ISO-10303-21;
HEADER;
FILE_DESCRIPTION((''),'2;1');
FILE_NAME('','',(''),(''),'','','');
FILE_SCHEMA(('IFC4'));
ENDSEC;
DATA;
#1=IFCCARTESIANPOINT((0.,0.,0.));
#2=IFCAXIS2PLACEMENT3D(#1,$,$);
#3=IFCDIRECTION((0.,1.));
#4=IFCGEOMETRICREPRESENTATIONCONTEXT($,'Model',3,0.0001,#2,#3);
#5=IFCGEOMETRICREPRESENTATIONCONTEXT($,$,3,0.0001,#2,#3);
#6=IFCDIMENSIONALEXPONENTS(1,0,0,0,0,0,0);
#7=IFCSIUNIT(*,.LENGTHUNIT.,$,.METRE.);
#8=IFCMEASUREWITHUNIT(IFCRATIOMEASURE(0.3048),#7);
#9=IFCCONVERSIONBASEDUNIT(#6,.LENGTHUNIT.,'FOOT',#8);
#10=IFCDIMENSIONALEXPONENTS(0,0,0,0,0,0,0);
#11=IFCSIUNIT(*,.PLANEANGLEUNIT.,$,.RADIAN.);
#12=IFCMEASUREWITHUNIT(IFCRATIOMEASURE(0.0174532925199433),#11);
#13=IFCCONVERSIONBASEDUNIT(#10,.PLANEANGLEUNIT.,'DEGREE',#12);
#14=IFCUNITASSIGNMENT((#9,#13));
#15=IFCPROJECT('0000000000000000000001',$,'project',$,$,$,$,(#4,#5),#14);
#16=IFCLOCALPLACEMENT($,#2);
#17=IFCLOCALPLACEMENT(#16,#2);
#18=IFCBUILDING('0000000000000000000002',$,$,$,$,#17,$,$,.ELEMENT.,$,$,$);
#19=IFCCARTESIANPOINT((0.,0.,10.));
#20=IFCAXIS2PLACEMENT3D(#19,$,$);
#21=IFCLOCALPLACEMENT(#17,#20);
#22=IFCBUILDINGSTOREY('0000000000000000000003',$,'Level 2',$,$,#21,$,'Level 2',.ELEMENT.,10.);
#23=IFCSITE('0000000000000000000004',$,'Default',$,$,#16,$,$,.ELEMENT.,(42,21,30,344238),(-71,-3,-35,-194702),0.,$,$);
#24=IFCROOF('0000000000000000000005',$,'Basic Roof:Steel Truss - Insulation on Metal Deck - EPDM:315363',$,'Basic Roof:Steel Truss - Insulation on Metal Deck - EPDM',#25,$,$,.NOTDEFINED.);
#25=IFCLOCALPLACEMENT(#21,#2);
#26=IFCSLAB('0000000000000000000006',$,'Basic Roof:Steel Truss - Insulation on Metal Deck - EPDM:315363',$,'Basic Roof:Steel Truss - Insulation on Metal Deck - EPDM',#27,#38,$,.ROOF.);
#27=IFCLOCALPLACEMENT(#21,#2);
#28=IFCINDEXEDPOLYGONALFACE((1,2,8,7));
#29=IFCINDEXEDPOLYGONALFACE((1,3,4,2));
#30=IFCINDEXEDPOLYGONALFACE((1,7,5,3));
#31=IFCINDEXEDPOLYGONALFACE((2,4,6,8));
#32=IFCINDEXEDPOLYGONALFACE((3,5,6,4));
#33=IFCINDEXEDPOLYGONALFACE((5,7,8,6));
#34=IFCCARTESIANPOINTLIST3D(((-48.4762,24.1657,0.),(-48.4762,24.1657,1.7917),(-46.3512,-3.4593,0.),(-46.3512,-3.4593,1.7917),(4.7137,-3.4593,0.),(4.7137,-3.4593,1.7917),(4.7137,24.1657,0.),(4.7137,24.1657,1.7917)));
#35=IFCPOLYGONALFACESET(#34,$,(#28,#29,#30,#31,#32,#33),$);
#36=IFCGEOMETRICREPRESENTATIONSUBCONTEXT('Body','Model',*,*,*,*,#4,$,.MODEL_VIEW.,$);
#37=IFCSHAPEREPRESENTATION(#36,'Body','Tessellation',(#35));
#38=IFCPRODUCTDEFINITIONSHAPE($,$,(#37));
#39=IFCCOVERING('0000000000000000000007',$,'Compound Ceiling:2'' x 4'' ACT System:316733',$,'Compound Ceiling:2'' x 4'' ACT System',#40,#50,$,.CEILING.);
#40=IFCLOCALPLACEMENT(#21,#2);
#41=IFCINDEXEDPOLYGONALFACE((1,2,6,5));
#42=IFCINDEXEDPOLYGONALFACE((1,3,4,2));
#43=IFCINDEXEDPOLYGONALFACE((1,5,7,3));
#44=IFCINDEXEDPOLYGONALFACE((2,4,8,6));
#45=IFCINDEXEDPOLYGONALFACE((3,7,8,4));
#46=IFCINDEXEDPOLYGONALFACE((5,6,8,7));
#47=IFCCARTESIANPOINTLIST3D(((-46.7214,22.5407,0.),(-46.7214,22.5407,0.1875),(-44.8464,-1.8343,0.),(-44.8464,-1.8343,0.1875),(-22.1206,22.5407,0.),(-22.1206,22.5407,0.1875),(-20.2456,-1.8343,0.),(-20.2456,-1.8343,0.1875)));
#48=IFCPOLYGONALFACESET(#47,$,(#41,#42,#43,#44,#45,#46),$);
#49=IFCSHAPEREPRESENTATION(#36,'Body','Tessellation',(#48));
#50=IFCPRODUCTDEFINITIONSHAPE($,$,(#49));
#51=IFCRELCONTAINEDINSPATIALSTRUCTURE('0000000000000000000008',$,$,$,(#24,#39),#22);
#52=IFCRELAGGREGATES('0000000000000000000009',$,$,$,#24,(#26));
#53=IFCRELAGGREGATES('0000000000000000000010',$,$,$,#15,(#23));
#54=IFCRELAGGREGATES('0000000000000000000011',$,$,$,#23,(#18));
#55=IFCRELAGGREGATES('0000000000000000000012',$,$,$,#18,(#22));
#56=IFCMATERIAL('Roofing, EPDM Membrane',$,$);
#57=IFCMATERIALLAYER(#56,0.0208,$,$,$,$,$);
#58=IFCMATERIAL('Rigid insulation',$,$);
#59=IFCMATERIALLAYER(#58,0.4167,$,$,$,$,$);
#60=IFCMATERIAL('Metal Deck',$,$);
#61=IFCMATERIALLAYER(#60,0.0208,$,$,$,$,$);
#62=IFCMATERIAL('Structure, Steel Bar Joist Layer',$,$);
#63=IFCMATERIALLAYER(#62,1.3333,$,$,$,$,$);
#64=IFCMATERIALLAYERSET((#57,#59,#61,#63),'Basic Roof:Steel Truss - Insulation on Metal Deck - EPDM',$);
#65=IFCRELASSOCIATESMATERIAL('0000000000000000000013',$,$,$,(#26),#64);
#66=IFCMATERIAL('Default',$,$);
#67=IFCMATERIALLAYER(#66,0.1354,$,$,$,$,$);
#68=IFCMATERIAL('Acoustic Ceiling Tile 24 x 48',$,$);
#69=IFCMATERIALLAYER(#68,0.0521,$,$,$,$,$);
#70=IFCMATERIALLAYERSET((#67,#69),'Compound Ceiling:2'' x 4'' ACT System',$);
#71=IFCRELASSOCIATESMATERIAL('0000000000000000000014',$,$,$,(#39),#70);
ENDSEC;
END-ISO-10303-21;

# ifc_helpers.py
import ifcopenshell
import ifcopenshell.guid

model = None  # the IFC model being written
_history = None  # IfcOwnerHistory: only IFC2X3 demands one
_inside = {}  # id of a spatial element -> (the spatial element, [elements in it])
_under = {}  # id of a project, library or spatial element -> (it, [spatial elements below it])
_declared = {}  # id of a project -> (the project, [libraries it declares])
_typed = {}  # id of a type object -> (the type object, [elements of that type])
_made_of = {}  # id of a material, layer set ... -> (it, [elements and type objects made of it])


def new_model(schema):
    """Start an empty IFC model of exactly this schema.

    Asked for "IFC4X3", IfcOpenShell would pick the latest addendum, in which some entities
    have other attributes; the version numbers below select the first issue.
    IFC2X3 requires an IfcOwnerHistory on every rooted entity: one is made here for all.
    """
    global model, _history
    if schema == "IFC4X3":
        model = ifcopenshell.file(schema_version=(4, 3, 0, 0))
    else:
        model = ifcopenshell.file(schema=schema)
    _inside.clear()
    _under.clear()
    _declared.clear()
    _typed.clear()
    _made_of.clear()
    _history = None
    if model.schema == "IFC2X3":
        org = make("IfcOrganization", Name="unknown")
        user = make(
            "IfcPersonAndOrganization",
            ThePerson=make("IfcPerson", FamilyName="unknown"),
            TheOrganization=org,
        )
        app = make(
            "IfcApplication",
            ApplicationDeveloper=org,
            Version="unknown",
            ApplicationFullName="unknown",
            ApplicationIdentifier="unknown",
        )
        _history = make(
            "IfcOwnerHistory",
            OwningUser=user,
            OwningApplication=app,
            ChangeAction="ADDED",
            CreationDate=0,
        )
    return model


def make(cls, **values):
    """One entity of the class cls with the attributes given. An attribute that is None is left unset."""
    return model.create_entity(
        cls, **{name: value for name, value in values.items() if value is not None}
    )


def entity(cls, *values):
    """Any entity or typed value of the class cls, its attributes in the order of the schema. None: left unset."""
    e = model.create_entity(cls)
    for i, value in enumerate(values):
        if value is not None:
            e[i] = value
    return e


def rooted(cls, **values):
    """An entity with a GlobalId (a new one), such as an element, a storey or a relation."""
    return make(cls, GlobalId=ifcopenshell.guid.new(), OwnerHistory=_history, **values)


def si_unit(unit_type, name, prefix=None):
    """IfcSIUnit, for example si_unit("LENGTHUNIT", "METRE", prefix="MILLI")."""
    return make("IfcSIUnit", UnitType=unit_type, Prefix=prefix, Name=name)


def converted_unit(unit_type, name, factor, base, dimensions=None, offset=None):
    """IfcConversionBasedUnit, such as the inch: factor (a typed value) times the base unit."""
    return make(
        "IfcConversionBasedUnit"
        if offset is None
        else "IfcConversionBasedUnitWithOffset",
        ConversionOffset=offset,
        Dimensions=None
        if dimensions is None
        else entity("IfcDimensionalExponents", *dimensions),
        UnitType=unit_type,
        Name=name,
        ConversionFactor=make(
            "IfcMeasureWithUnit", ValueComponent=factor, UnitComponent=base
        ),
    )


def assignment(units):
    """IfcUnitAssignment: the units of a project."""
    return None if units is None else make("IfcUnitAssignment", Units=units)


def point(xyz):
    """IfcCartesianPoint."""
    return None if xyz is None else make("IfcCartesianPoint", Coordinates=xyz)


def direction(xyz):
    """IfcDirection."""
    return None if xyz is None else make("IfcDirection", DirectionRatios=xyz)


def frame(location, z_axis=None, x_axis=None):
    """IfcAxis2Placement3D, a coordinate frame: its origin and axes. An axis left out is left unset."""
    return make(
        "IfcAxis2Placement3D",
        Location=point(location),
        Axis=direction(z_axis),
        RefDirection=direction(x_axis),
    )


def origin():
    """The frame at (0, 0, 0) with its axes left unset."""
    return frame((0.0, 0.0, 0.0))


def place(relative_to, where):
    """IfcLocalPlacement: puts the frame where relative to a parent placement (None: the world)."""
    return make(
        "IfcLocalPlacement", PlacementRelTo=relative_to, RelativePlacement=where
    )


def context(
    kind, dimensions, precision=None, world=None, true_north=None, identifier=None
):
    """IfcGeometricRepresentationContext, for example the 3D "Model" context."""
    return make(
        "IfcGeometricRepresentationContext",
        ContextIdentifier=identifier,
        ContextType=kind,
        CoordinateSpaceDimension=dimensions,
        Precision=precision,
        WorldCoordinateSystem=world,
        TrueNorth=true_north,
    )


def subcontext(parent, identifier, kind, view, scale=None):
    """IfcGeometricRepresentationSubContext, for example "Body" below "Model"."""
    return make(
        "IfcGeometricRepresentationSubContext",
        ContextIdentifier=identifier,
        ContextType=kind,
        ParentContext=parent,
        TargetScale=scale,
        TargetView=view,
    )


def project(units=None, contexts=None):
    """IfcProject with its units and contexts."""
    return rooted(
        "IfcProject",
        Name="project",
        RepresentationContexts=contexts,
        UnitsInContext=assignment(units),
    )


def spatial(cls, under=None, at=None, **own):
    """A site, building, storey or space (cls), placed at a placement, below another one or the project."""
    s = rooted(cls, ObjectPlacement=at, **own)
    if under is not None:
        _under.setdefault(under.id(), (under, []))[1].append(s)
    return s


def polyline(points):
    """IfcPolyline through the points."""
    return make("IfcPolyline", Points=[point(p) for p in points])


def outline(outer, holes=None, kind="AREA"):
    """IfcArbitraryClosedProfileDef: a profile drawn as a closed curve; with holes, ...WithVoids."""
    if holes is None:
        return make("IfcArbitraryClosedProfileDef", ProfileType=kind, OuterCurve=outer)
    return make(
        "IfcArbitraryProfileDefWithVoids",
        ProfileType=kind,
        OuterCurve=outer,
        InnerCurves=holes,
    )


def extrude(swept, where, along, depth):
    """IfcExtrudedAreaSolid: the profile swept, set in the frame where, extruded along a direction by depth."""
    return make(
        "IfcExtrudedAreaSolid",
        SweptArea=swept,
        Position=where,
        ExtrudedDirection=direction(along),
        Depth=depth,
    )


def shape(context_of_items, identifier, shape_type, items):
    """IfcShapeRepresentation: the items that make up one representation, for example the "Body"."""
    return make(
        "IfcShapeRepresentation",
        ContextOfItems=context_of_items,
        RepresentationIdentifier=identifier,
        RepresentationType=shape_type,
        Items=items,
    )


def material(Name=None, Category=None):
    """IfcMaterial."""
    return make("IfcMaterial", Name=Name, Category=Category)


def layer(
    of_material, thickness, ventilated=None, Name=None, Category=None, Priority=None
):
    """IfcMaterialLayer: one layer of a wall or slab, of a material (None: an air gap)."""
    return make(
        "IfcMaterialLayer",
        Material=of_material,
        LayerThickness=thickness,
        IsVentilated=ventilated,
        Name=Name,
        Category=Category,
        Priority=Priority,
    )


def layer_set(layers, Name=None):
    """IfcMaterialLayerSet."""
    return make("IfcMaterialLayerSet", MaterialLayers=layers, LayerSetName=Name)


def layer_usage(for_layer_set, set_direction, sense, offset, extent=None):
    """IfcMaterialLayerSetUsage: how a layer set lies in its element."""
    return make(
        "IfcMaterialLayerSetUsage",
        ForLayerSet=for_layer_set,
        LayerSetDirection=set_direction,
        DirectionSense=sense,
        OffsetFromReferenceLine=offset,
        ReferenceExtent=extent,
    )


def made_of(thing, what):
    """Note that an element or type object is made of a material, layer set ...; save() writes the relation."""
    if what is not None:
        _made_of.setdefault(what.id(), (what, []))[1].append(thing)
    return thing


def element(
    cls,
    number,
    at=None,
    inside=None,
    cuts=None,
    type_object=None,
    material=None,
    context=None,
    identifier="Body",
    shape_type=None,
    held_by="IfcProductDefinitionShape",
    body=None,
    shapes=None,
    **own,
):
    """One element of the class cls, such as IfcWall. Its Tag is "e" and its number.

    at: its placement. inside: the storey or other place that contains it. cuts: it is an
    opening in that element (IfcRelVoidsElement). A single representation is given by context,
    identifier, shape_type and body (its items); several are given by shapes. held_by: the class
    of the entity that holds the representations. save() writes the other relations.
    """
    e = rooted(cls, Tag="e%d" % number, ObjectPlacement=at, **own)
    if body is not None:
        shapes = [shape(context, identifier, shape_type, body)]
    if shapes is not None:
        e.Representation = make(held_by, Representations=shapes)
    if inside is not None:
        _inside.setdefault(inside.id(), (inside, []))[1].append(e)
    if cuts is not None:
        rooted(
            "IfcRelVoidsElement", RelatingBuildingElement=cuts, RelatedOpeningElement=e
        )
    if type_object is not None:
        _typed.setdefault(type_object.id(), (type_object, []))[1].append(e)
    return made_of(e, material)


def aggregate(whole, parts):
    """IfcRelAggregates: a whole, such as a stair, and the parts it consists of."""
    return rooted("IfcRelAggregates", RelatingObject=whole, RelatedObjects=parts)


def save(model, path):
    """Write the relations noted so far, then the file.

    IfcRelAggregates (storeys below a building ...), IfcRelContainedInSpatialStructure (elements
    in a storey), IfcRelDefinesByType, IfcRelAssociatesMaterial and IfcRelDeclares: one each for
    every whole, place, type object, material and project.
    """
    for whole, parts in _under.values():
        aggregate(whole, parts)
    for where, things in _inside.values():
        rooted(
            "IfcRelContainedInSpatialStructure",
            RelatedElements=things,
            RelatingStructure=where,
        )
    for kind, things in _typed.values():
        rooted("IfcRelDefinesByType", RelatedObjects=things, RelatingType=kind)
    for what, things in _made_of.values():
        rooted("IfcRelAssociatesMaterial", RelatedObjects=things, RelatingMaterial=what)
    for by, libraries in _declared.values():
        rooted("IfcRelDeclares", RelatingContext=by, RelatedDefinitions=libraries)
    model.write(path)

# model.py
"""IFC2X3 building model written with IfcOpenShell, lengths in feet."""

from ifc_helpers import new_model, entity, si_unit, converted_unit, direction, frame, origin, place, context, subcontext, project, spatial, polyline, outline, extrude, material, layer, layer_set, layer_usage, element, aggregate, save


model = new_model("IFC2X3")

# Units and contexts
model_context = context("Model", 3, precision=0.0001, world=origin(), true_north=direction((0.0, 1.0)))
context_of_model = context(None, 3, precision=0.0001, world=origin(), true_north=direction((0.0, 1.0)))
body_context = subcontext(model_context, "Body", "Model", "MODEL_VIEW")
ifc_project = project(units=[converted_unit("LENGTHUNIT", "FOOT", entity("IfcRatioMeasure", 0.3048), si_unit("LENGTHUNIT", "METRE"), dimensions=[1, 0, 0, 0, 0, 0, 0]), converted_unit("PLANEANGLEUNIT", "DEGREE", entity("IfcRatioMeasure", 0.0174532925199433), si_unit("PLANEANGLEUNIT", "RADIAN"), dimensions=[0, 0, 0, 0, 0, 0, 0])], contexts=[model_context, context_of_model])

# Site, building, storey
site_placement = place(None, origin())
site = spatial("IfcSite", under=ifc_project, at=site_placement, Name="Default", CompositionType="ELEMENT", RefLatitude=(42, 21, 30, 344238), RefLongitude=(-71, -3, -35, -194702), RefElevation=0.0)
building_placement = place(site_placement, origin())
building = spatial("IfcBuilding", under=site, at=building_placement, CompositionType="ELEMENT")
storey_placement = place(building_placement, frame((0.0, 0.0, 10.0)))
storey = spatial("IfcBuildingStorey", under=building, at=storey_placement, Name="Level 2", LongName="Level 2", CompositionType="ELEMENT", Elevation=10.0)

# Roof, slab
roof_placement = place(storey_placement, frame((-48.4762, -3.4593, 0.0)))
roof = element("IfcRoof", 1, at=roof_placement, inside=storey, Name="Basic Roof:Steel Truss - Insulation on Metal Deck - EPDM:315363", ObjectType="Basic Roof:Steel Truss - Insulation on Metal Deck - EPDM", ShapeType="NOTDEFINED")
ifc_material_1 = material(Name="Roofing, EPDM Membrane")
ifc_layer_1 = layer(ifc_material_1, 0.0208)
ifc_material_2 = material(Name="Rigid insulation")
ifc_layer_2 = layer(ifc_material_2, 0.4167)
ifc_material_3 = material(Name="Metal Deck")
ifc_layer_3 = layer(ifc_material_3, 0.0208)
ifc_material_4 = material(Name="Structure, Steel Bar Joist Layer")
ifc_layer_4 = layer(ifc_material_4, 1.3333)
ifc_layer_set_1 = layer_set([ifc_layer_1, ifc_layer_2, ifc_layer_3, ifc_layer_4], Name="Basic Roof:Steel Truss - Insulation on Metal Deck - EPDM")
slab_placement = place(roof_placement, origin())
slab = element("IfcSlab", 2, at=slab_placement, material=ifc_layer_set_1, Name="Basic Roof:Steel Truss - Insulation on Metal Deck - EPDM:315363", ObjectType="Basic Roof:Steel Truss - Insulation on Metal Deck - EPDM", PredefinedType="ROOF", context=body_context, shape_type="SweptSolid", body=[
    extrude(outline(polyline([(-26.595, 13.8125), (-24.47, -13.8125), (26.595, -13.8125), (26.595, 13.8125), (-26.595, 13.8125)])), frame((26.595, 13.8125, 0.0)), (0.0, 0.0, 1.0), 1.7917),
])
aggregate(roof, [slab])

# Covering
ifc_material_5 = material(Name="Default")
ifc_layer_5 = layer(ifc_material_5, 0.1354)
ifc_material_6 = material(Name="Acoustic Ceiling Tile 24 x 48")
ifc_layer_6 = layer(ifc_material_6, 0.0521)
ifc_layer_set_2 = layer_set([ifc_layer_5, ifc_layer_6], Name="Compound Ceiling:2' x 4' ACT System")
ifc_layer_usage_1 = layer_usage(ifc_layer_set_2, "AXIS3", "NEGATIVE", 0.0)
covering_1_placement = place(storey_placement, origin())
element("IfcCovering", 3, at=covering_1_placement, inside=storey, material=ifc_layer_usage_1, Name="Compound Ceiling:2' x 4' ACT System:316733", ObjectType="Compound Ceiling:2' x 4' ACT System", PredefinedType="CEILING", context=body_context, shape_type="SweptSolid", body=[
    extrude(outline(polyline([(-13.1669, -12.2642), (11.2801, -12.2642), (13.1669, 12.2642), (-11.2801, 12.2642), (-13.1669, -12.2642)])), frame((-33.4835, 10.3532, 0.0), z_axis=(0.0, 0.0, 1.0), x_axis=(0.076696, -0.997054, 0.0)), (0.0, 0.0, 1.0), 0.1875),
])

save(model, "model.ifc")
